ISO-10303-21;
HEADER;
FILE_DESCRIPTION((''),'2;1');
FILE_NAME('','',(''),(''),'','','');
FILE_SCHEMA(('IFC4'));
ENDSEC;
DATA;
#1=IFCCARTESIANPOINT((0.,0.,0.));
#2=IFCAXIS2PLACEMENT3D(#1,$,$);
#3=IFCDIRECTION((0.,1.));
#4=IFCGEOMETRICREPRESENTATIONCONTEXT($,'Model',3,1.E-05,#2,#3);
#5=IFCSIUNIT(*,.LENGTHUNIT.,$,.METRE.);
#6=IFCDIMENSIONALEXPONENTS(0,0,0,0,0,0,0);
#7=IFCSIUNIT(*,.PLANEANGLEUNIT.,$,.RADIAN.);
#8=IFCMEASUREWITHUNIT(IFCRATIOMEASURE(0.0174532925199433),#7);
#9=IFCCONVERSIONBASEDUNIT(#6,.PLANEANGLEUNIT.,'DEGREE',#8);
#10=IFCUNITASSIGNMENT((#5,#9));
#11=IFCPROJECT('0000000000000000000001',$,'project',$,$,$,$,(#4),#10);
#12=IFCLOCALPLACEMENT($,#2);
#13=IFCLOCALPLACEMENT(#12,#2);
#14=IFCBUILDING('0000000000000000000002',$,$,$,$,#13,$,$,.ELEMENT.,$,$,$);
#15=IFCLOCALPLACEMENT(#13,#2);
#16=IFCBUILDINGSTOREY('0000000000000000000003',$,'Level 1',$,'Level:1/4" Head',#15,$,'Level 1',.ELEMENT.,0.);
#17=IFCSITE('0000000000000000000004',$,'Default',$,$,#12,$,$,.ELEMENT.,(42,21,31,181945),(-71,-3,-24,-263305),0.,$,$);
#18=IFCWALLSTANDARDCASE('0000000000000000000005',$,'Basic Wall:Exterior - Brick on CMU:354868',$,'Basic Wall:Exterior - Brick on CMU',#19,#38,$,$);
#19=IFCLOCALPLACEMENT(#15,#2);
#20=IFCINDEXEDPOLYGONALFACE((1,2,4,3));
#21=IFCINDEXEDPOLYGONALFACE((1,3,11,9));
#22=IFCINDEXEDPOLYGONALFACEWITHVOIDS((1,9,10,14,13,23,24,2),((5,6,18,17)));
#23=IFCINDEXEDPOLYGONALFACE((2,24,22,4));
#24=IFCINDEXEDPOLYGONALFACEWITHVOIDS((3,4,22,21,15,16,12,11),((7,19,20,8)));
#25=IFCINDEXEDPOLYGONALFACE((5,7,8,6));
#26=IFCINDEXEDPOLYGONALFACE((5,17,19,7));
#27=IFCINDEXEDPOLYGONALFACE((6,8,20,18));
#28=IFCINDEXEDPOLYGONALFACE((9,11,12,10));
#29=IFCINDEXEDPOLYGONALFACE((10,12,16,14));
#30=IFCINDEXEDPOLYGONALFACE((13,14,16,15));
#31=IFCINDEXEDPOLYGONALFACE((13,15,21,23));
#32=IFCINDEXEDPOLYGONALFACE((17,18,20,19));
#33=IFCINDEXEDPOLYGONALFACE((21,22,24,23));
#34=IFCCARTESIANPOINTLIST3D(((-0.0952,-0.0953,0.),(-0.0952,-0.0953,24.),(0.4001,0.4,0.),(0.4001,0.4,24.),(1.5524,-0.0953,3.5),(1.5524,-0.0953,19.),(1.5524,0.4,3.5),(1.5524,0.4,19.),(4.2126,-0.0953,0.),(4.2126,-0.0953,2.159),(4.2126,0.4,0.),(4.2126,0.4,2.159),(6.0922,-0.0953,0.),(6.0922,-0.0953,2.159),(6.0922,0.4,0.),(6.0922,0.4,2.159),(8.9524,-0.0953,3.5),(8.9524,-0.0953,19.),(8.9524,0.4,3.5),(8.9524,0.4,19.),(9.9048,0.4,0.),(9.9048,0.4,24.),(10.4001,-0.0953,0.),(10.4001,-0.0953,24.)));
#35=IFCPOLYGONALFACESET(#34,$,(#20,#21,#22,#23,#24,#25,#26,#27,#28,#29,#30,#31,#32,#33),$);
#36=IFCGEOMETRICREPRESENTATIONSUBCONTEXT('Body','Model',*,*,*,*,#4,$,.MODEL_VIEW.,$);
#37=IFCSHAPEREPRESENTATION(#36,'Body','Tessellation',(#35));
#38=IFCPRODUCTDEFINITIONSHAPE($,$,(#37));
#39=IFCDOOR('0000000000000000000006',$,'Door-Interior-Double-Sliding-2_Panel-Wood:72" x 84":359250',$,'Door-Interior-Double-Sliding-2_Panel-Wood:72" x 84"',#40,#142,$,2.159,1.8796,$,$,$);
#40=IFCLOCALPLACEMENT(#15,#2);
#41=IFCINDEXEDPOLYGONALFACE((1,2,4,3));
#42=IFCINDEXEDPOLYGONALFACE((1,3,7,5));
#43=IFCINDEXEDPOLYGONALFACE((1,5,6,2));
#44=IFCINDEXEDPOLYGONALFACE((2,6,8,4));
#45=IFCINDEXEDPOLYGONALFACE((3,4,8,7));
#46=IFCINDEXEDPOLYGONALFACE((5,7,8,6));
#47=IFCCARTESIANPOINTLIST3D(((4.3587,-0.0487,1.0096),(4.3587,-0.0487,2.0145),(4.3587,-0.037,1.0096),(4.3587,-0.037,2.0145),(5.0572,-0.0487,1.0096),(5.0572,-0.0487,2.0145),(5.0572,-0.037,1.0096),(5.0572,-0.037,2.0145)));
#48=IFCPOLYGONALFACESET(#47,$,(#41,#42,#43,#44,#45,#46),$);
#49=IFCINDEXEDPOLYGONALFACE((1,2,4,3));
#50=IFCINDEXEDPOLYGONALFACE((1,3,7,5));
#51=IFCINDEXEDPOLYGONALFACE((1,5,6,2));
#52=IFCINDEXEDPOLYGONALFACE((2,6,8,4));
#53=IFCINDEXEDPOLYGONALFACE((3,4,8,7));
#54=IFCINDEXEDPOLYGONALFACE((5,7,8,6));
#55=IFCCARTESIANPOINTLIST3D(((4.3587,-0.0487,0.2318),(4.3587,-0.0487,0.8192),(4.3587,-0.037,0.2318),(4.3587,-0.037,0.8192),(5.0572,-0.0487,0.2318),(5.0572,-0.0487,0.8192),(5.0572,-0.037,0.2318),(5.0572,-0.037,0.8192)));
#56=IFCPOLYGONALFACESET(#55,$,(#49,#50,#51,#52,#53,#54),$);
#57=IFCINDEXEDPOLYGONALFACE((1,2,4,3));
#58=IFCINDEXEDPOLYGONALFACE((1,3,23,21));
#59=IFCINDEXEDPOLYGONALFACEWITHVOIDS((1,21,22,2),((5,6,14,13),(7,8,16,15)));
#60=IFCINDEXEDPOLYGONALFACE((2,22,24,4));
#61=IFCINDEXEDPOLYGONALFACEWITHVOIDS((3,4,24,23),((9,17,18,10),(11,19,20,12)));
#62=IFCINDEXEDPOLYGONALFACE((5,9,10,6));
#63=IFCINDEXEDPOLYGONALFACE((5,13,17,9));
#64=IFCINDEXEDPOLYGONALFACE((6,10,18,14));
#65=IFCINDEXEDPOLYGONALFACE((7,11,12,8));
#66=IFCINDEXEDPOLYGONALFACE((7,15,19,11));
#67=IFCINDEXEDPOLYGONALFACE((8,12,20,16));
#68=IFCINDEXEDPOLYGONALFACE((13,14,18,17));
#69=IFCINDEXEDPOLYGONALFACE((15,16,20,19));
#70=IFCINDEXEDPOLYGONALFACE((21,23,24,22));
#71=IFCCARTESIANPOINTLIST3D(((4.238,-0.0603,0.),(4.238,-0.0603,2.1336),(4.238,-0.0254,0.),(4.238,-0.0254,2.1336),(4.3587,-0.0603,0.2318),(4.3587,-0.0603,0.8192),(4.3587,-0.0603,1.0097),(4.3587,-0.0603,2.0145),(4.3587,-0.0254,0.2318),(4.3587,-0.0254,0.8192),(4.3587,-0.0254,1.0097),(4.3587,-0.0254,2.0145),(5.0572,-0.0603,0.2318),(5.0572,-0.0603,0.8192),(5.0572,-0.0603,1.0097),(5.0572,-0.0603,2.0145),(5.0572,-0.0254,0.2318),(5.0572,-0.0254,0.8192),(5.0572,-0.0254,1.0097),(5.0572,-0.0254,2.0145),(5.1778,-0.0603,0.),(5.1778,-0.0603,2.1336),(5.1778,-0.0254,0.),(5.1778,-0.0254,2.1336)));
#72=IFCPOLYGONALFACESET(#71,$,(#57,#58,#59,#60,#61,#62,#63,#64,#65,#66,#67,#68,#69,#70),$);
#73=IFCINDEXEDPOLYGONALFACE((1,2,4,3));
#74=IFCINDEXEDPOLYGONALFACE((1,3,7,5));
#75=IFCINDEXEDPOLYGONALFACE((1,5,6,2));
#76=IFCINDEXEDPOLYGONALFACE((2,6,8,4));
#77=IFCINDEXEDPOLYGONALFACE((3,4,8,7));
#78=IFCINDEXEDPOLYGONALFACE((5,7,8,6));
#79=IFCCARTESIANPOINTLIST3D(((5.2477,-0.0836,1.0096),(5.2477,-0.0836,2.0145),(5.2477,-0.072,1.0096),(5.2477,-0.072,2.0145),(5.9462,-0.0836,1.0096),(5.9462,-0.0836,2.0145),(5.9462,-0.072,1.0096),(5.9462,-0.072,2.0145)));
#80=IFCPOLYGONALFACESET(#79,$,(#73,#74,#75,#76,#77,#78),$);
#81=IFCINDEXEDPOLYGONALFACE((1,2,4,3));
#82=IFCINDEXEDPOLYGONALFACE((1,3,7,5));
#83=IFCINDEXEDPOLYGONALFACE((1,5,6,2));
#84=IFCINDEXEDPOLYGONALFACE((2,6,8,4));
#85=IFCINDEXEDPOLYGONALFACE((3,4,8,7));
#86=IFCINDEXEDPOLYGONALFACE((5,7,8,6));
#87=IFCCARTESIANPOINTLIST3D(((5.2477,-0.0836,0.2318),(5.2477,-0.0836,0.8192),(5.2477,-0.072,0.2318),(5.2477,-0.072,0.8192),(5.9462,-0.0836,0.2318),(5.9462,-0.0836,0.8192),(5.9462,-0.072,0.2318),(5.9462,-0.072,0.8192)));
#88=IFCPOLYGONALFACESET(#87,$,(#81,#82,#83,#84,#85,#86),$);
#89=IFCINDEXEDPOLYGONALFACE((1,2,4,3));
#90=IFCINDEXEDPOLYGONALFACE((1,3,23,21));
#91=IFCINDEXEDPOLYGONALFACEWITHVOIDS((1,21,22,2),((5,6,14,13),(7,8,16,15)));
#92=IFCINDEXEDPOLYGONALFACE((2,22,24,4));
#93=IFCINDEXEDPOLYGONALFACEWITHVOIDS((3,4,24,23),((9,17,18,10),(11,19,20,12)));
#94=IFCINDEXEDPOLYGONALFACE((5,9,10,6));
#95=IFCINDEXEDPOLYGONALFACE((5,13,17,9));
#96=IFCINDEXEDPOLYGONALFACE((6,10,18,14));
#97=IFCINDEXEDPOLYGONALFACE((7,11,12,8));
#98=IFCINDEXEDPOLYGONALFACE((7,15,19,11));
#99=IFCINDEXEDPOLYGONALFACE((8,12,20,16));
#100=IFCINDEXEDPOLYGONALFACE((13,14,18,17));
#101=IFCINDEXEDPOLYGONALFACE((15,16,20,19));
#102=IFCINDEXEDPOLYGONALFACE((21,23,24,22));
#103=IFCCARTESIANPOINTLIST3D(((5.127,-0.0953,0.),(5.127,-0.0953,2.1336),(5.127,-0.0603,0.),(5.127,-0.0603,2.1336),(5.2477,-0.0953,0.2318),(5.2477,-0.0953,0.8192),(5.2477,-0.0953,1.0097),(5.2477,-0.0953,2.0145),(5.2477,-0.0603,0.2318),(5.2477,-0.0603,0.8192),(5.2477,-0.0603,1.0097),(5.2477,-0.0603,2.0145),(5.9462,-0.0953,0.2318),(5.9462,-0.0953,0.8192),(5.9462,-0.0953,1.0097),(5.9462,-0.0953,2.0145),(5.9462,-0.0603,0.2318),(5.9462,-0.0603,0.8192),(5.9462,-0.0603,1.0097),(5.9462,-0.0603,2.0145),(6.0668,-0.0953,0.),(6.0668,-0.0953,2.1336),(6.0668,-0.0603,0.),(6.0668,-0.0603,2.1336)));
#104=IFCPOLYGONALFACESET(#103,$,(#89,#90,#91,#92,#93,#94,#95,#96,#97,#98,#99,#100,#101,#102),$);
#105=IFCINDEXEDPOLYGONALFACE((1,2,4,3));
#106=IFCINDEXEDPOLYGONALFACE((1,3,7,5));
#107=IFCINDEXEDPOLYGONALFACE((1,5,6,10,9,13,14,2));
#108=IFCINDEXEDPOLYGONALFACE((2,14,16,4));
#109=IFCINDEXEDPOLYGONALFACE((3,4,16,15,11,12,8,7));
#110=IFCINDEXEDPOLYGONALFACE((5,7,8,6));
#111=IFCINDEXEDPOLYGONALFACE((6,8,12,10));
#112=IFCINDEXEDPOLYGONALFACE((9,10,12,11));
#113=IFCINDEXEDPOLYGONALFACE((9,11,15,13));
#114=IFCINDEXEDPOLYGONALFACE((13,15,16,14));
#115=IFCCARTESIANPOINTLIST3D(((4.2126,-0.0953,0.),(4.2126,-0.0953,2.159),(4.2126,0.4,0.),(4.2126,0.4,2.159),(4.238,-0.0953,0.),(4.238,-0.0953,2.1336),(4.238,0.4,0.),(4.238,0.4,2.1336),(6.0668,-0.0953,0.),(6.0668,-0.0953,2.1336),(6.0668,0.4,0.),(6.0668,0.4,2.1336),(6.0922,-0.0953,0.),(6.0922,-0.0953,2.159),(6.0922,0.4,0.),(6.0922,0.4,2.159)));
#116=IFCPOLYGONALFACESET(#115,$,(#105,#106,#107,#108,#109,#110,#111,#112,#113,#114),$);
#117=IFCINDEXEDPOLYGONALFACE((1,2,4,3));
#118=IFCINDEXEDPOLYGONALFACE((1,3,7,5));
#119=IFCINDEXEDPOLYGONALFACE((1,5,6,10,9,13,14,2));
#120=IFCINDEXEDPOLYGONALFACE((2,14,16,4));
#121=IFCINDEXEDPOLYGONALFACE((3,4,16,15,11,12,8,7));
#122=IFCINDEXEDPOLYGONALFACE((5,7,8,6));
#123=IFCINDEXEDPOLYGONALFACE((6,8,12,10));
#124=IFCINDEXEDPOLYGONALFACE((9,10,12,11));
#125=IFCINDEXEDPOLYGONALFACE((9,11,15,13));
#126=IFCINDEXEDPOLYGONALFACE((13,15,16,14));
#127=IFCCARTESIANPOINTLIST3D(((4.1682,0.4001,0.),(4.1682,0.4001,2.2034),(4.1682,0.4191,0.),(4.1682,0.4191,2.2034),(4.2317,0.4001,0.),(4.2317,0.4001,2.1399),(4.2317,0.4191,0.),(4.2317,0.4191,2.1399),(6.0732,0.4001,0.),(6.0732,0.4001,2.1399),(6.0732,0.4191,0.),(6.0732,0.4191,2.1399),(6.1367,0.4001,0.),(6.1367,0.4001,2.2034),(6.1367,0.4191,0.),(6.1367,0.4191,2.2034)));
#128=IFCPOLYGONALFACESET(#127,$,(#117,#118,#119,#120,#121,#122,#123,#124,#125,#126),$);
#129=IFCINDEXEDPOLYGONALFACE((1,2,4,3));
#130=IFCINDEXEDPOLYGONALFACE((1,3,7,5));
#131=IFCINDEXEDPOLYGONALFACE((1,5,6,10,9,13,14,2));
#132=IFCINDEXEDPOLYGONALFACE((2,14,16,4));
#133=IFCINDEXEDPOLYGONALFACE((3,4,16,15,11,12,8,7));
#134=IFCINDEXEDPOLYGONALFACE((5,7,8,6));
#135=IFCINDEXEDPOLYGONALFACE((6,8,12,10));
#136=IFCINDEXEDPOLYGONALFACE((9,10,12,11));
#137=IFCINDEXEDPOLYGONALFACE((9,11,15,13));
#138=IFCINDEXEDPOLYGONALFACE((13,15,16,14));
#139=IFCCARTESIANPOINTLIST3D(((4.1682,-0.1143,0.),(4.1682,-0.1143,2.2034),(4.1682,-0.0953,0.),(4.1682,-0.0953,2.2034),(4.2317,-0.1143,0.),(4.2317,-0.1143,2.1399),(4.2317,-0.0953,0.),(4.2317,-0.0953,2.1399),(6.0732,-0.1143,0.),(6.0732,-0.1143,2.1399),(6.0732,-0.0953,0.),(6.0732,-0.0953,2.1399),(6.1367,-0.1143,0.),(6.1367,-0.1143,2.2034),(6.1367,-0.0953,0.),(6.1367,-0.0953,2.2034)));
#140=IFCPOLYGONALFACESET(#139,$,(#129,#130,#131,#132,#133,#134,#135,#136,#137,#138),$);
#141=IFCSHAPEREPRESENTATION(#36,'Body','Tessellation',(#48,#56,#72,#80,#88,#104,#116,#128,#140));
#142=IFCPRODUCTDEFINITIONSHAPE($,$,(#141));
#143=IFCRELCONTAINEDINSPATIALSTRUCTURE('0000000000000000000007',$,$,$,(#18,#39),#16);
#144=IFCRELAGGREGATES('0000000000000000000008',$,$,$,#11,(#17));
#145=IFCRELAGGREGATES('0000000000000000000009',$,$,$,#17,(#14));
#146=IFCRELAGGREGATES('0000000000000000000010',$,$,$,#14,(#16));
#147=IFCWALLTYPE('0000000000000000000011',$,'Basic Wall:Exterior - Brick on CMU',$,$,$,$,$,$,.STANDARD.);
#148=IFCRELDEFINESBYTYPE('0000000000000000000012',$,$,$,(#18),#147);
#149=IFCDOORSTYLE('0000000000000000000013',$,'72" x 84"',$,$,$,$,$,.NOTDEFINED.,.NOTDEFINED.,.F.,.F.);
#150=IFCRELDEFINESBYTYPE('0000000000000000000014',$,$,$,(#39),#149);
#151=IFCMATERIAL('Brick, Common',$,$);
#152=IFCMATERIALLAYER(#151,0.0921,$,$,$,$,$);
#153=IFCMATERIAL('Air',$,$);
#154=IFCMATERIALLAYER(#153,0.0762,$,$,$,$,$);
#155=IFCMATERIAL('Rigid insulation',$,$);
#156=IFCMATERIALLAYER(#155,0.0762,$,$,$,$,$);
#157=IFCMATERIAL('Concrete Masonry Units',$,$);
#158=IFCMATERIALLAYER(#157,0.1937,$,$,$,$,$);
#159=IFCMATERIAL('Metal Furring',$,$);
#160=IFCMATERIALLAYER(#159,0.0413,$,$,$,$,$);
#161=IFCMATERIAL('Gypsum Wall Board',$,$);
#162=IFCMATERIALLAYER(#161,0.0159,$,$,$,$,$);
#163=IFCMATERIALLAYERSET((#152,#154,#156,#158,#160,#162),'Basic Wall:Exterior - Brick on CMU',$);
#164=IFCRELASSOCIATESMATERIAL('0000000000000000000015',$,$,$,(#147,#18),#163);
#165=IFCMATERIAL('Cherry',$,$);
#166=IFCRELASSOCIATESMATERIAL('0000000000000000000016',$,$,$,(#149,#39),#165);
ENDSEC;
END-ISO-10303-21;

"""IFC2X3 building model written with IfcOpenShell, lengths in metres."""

from ifc_helpers import new_model, entity, si_unit, converted_unit, direction, frame, frame_2d, origin, origin_2d_with_axis, place, context, subcontext, project, spatial, polyline, rectangle, outline, extrude, source, transform, mapped, material, layer, layer_set, layer_usage, type_object, type_shapes, element, fill, save


model = new_model("IFC2X3")

# Units and contexts
model_context = context("Model", 3, precision=1e-05, world=origin(), true_north=direction((0.0, 1.0)))
body_context = subcontext(model_context, "Body", "Model", "MODEL_VIEW")
ifc_project = project(units=[si_unit("LENGTHUNIT", "METRE"), converted_unit("PLANEANGLEUNIT", "DEGREE", entity("IfcRatioMeasure", 0.0174532925199433), si_unit("PLANEANGLEUNIT", "RADIAN"), dimensions=[0, 0, 0, 0, 0, 0, 0])], contexts=[model_context])

# Site, building, storey
site_placement = place(None, origin())
site = spatial("IfcSite", under=ifc_project, at=site_placement, Name="Default", CompositionType="ELEMENT", RefLatitude=(42, 21, 31, 181945), RefLongitude=(-71, -3, -24, -263305), RefElevation=0.0)
building_placement = place(site_placement, origin())
building = spatial("IfcBuilding", under=site, at=building_placement, CompositionType="ELEMENT")
storey_placement = place(building_placement, origin())
storey = spatial("IfcBuildingStorey", under=building, at=storey_placement, Name="Level 1", ObjectType="Level:1/4\" Head", LongName="Level 1", CompositionType="ELEMENT", Elevation=0.0)

# Wall, openings, door
ifc_material_1 = material(Name="Brick, Common")
ifc_layer_1 = layer(ifc_material_1, 0.0921)
ifc_material_2 = material(Name="Air")
ifc_layer_2 = layer(ifc_material_2, 0.0762)
ifc_material_3 = material(Name="Rigid insulation")
ifc_layer_3 = layer(ifc_material_3, 0.0762)
ifc_material_4 = material(Name="Concrete Masonry Units")
ifc_layer_4 = layer(ifc_material_4, 0.1937)
ifc_material_5 = material(Name="Metal Furring")
ifc_layer_5 = layer(ifc_material_5, 0.0413)
ifc_material_6 = material(Name="Gypsum Wall Board")
ifc_layer_6 = layer(ifc_material_6, 0.0159)
ifc_layer_set_1 = layer_set([ifc_layer_1, ifc_layer_2, ifc_layer_3, ifc_layer_4, ifc_layer_5, ifc_layer_6], Name="Basic Wall:Exterior - Brick on CMU")
ifc_layer_usage_1 = layer_usage(ifc_layer_set_1, "AXIS2", "POSITIVE", -0.2477)
wall_type = type_object("IfcWallType", Name="Basic Wall:Exterior - Brick on CMU", PredefinedType="STANDARD", material=ifc_layer_set_1)
wall_placement = place(storey_placement, frame((-0.0952, 0.1524, 0.0)))
wall = element("IfcWallStandardCase", 1, at=wall_placement, inside=storey, type_object=wall_type, material=ifc_layer_usage_1, Name="Basic Wall:Exterior - Brick on CMU:354868", ObjectType="Basic Wall:Exterior - Brick on CMU", context=body_context, shape_type="SweptSolid", body=[
    extrude(outline(polyline([(0.0, -0.2477), (10.4953, -0.2477), (10.0, 0.2477), (0.4953, 0.2477), (0.0, -0.2477)])), origin(), (0.0, 0.0, 1.0), 24.0),
])
opening_1_placement = place(wall_placement, frame((1.6477, -0.4001, 3.5)))
element("IfcOpeningElement", 2, at=opening_1_placement, cuts=wall, ObjectType="Opening", context=body_context, shape_type="SweptSolid", body=[
    extrude(rectangle(XDim=15.5, YDim=7.4, at=frame_2d((0.0, 0.0), x_axis=(1.0, 0.0))), frame((3.7, 0.0, 7.75), z_axis=(0.0, 1.0, 0.0), x_axis=(0.0, 0.0, 1.0)), (0.0, 0.0, 1.0), 0.8001),
])
opening_2_placement = place(wall_placement, frame((6.1875, 0.2476, 0.0)))
opening_2 = element("IfcOpeningElement", 3, at=opening_2_placement, cuts=wall, ObjectType="Opening", context=body_context, shape_type="SweptSolid", body=[
    extrude(rectangle(XDim=2.159, YDim=1.8796, at=frame_2d((1.0795, 0.9398), x_axis=(1.0, 0.0))), frame((0.0, 0.0, 0.0), z_axis=(0.0, -1.0, 0.0), x_axis=(0.0, 0.0, 1.0)), (0.0, 0.0, 1.0), 0.4953),
])
ifc_material_7 = material(Name="Cherry")
door_style = type_object("IfcDoorStyle", Name="72\" x 84\"", ConstructionType="NOTDEFINED", OperationType="NOTDEFINED", ParameterTakesPrecedence=False, Sizeable=False, material=ifc_material_7)
shared_shape_1 = source(origin(), body_context, "Body", "SweptSolid", [
    extrude(rectangle(XDim=0.0116, YDim=0.6985, at=frame_2d((0.0, 0.0), x_axis=(1.0, 0.0))), frame((1.3843, 0.4429, 1.0096), z_axis=(0.0, 0.0, 1.0), x_axis=(0.0, 1.0, 0.0)), (0.0, 0.0, 1.0), 1.0049),
    extrude(rectangle(XDim=0.0116, YDim=0.6985, at=frame_2d((0.0, 0.0), x_axis=(1.0, 0.0))), frame((1.3843, 0.4429, 0.2318), z_axis=(0.0, 0.0, 1.0), x_axis=(0.0, 1.0, 0.0)), (0.0, 0.0, 1.0), 0.5874),
    extrude(outline(polyline([(-0.4699, -1.0668), (0.4699, -1.0668), (0.4699, 1.0668), (-0.4699, 1.0668), (-0.4699, -1.0668)]), holes=[polyline([(-0.3492, -0.9477), (-0.3492, 0.0571), (0.3492, 0.0571), (0.3492, -0.9477), (-0.3492, -0.9477)]), polyline([(-0.3492, 0.2476), (-0.3492, 0.835), (0.3492, 0.835), (0.3492, 0.2476), (-0.3492, 0.2476)])]), frame((1.3843, 0.4255, 1.0668), z_axis=(0.0, 1.0, 0.0), x_axis=(1.0, 0.0, 0.0)), (0.0, 0.0, 1.0), 0.0349),
    extrude(rectangle(XDim=0.0116, YDim=0.6985, at=origin_2d_with_axis()), frame((0.4953, 0.4778, 1.0096), z_axis=(0.0, 0.0, 1.0), x_axis=(0.0, 1.0, 0.0)), (0.0, 0.0, 1.0), 1.0049),
    extrude(rectangle(XDim=0.0116, YDim=0.6985, at=origin_2d_with_axis()), frame((0.4953, 0.4778, 0.2318), z_axis=(0.0, 0.0, 1.0), x_axis=(0.0, 1.0, 0.0)), (0.0, 0.0, 1.0), 0.5874),
    extrude(outline(polyline([(-0.4699, -1.0668), (0.4699, -1.0668), (0.4699, 1.0668), (-0.4699, 1.0668), (-0.4699, -1.0668)]), holes=[polyline([(-0.3493, -0.9477), (-0.3493, 0.0571), (0.3493, 0.0571), (0.3493, -0.9477), (-0.3493, -0.9477)]), polyline([(-0.3493, 0.2476), (-0.3493, 0.835), (0.3493, 0.835), (0.3493, 0.2476), (-0.3493, 0.2476)])]), frame((0.4953, 0.4604, 1.0668), z_axis=(0.0, 1.0, 0.0), x_axis=(1.0, 0.0, 0.0)), (0.0, 0.0, 1.0), 0.0349),
    extrude(outline(polyline([(-1.0732, -0.9144), (-1.0732, -0.9398), (1.0858, -0.9398), (1.0858, 0.9398), (-1.0732, 0.9398), (-1.0732, 0.9144), (1.0604, 0.9144), (1.0604, -0.9144), (-1.0732, -0.9144)])), frame((0.9398, 0.0, 1.0732), z_axis=(0.0, -1.0, 0.0), x_axis=(0.0, 0.0, 1.0)), (0.0, 0.0, -1.0), 0.4953),
    extrude(outline(polyline([(-1.0858, -0.9207), (-1.0858, -0.9842), (1.1176, -0.9842), (1.1176, 0.9842), (-1.0858, 0.9842), (-1.0858, 0.9207), (1.0541, 0.9207), (1.0541, -0.9207), (-1.0858, -0.9207)])), frame((0.9398, -0.0191, 1.0858), z_axis=(0.0, -1.0, 0.0), x_axis=(0.0, 0.0, 1.0)), (0.0, 0.0, -1.0), 0.0191),
    extrude(outline(polyline([(-1.0858, -0.9207), (-1.0858, -0.9842), (1.1176, -0.9842), (1.1176, 0.9842), (-1.0858, 0.9842), (-1.0858, 0.9207), (1.0541, 0.9207), (1.0541, -0.9207), (-1.0858, -0.9207)])), frame((0.9398, 0.4953, 1.0858), z_axis=(0.0, -1.0, 0.0), x_axis=(0.0, 0.0, 1.0)), (0.0, 0.0, -1.0), 0.0191),
])
type_shapes(door_style, [shared_shape_1])
door_placement = place(opening_2_placement, frame((0.0, 0.0, 0.0), z_axis=(0.0, 0.0, 1.0), x_axis=(-1.0, 0.0, 0.0)))
door = element("IfcDoor", 4, at=door_placement, inside=storey, type_object=door_style, material=ifc_material_7, Name="Door-Interior-Double-Sliding-2_Panel-Wood:72\" x 84\":359250", ObjectType="Door-Interior-Double-Sliding-2_Panel-Wood:72\" x 84\"", OverallHeight=2.159, OverallWidth=1.8796, context=body_context, shape_type="MappedRepresentation", body=[
    mapped(shared_shape_1, transform((0.0, 0.0, 0.0), scale=1.0)),
])
fill(opening_2, door)

save(model, "model.ifc")
